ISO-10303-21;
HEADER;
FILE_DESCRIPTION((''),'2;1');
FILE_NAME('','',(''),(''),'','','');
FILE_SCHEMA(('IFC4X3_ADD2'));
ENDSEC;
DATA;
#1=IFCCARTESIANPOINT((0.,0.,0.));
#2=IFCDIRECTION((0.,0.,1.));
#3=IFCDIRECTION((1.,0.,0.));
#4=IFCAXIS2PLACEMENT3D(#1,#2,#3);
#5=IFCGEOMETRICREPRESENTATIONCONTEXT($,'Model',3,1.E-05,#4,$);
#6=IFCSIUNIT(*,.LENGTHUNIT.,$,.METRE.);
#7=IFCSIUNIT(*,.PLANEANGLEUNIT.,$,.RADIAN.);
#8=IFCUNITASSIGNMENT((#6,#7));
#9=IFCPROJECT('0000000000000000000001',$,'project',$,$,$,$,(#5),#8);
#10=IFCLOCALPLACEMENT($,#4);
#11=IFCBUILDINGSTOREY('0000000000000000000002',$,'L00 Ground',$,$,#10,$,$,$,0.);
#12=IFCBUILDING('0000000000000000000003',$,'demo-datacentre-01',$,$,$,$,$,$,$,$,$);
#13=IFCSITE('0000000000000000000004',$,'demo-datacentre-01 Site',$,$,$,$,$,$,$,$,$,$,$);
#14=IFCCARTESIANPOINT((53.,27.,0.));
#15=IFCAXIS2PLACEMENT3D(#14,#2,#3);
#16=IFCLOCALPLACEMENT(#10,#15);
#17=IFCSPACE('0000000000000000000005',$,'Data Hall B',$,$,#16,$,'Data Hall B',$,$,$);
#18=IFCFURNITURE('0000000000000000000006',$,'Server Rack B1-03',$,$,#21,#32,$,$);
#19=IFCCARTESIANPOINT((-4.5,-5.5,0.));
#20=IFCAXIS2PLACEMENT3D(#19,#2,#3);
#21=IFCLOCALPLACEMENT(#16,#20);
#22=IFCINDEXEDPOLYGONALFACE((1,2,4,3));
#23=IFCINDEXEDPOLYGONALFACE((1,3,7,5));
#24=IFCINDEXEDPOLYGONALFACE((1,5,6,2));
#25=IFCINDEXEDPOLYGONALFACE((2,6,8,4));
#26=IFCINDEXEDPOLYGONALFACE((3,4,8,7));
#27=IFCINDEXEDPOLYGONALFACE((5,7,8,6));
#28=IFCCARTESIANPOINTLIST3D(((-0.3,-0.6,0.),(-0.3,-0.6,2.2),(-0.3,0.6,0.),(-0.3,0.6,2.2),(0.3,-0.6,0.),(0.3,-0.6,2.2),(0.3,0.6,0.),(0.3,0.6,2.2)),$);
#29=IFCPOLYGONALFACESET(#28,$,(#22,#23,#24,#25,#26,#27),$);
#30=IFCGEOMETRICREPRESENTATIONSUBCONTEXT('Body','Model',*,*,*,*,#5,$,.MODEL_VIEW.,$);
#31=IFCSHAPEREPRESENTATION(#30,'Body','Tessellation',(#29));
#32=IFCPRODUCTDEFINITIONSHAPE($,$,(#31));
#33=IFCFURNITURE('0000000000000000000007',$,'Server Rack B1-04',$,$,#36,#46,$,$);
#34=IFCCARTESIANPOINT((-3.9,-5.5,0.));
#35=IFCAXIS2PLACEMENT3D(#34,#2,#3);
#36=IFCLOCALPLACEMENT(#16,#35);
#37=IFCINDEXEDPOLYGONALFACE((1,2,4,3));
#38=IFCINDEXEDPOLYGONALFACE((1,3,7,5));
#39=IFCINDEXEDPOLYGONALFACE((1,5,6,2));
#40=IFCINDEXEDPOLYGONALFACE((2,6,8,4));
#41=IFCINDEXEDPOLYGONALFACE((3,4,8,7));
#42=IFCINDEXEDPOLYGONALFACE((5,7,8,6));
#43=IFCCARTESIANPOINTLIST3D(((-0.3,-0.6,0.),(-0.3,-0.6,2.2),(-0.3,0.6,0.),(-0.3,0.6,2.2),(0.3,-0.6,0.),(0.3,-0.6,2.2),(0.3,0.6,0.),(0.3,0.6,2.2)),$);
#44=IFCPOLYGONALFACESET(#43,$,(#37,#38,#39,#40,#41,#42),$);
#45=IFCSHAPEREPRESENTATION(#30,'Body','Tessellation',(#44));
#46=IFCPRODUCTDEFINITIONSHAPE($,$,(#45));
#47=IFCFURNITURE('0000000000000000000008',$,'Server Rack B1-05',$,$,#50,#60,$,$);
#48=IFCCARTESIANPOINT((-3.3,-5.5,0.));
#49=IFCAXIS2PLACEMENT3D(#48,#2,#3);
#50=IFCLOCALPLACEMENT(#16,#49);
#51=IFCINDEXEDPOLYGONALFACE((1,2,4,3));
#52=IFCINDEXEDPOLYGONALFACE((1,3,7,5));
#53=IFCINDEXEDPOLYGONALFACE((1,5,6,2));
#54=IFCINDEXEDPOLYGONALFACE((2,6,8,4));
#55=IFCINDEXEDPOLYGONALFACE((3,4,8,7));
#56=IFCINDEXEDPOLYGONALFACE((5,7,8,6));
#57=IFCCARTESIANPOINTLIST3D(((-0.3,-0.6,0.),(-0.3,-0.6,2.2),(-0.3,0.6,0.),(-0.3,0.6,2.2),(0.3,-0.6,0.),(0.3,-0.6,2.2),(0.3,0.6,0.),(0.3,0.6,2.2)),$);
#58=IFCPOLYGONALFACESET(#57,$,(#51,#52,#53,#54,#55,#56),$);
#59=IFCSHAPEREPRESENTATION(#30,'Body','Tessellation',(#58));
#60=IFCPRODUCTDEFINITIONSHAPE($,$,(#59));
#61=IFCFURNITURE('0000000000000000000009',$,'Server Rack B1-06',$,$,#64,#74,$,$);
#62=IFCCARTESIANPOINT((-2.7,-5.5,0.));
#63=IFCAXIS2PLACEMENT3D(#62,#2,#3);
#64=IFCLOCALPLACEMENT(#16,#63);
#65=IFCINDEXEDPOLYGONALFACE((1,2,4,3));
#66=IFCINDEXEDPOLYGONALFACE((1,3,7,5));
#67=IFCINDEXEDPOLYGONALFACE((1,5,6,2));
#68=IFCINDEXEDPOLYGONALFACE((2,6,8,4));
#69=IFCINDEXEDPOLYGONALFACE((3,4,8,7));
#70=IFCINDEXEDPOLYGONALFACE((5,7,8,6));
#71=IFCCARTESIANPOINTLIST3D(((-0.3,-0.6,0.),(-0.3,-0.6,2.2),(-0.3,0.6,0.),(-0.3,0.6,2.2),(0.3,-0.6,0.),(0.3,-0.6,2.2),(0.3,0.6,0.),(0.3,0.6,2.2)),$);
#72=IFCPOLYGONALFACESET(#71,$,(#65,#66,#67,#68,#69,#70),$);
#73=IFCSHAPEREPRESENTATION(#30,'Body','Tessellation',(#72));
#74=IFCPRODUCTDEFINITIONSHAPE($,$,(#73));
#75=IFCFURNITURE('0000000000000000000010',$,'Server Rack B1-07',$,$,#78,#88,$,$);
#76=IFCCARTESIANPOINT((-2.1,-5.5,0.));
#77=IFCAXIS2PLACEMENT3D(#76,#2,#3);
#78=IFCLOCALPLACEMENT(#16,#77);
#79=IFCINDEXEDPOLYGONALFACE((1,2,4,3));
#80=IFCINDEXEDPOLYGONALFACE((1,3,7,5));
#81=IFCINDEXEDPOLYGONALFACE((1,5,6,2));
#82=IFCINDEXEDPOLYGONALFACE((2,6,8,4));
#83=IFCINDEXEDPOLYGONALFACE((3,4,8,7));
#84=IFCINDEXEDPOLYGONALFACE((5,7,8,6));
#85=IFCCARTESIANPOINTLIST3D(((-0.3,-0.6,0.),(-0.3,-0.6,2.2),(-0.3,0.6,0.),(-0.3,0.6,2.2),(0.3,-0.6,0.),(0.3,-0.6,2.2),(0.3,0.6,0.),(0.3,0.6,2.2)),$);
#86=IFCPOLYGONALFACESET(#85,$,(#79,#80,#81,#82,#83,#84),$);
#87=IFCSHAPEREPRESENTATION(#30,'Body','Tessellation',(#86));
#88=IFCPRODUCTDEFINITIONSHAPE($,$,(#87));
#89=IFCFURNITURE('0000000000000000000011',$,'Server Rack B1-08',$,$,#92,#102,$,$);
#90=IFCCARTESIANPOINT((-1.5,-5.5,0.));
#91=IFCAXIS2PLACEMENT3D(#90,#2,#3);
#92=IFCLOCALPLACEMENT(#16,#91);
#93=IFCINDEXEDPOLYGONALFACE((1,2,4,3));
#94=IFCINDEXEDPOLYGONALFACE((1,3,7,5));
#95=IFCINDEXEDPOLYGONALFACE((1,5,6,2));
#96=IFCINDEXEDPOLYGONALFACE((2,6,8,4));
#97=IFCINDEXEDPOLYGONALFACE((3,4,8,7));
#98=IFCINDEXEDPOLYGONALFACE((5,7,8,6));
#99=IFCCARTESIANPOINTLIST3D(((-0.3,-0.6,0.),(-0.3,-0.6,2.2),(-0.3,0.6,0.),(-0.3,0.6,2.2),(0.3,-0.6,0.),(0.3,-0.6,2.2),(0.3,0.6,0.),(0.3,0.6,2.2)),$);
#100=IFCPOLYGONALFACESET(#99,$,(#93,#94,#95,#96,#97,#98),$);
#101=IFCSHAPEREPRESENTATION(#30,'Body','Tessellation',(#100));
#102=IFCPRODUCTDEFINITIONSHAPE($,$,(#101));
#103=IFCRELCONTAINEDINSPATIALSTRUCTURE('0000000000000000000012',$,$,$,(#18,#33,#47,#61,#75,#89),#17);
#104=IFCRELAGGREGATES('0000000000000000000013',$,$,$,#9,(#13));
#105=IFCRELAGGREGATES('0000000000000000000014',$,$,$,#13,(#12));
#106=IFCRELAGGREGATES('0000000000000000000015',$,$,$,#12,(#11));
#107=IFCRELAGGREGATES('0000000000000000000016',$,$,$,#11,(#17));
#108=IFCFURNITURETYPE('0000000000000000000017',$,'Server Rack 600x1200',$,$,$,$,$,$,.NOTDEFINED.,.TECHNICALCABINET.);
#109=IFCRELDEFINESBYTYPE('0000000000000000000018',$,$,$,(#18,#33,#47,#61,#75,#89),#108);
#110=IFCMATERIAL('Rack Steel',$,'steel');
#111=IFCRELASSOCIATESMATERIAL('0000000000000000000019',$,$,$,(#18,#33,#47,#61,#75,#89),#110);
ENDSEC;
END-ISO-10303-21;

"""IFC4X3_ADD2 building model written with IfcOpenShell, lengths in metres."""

from ifc_helpers import new_model, si_unit, frame, origin_with_axes, place, context, subcontext, project, spatial, rectangle, extrude, material, type_object, element, save


model = new_model("IFC4X3_ADD2")

# Units and contexts
model_context = context("Model", 3, precision=1e-05, world=origin_with_axes())
body_context = subcontext(model_context, "Body", "Model", "MODEL_VIEW")
ifc_project = project(units=[si_unit("LENGTHUNIT", "METRE"), si_unit("PLANEANGLEUNIT", "RADIAN")], contexts=[model_context])

# Site, building, storey
site = spatial("IfcSite", under=ifc_project, Name="demo-datacentre-01 Site")
building = spatial("IfcBuilding", under=site, Name="demo-datacentre-01")
storey_placement = place(None, origin_with_axes())
storey = spatial("IfcBuildingStorey", under=building, at=storey_placement, Name="L00 Ground", Elevation=0.0)

# Shared definitions
space_placement = place(storey_placement, frame((53.0, 27.0, 0.0), z_axis=(0.0, 0.0, 1.0), x_axis=(1.0, 0.0, 0.0)))
space = spatial("IfcSpace", under=storey, at=space_placement, Name="Data Hall B", LongName="Data Hall B")

# Furniture
ifc_material_1 = material(Name="Rack Steel", Category="steel")
furniture_type = type_object("IfcFurnitureType", Name="Server Rack 600x1200", AssemblyPlace="NOTDEFINED", PredefinedType="TECHNICALCABINET")
for number, where, z_axis, x_axis, name in (
    (1, (-4.5, -5.5, 0.0), (0.0, 0.0, 1.0), (1.0, 0.0, 0.0), "Server Rack B1-03"),
    (2, (-3.9, -5.5, 0.0), (0.0, 0.0, 1.0), (1.0, 0.0, 0.0), "Server Rack B1-04"),
    (3, (-3.3, -5.5, 0.0), (0.0, 0.0, 1.0), (1.0, 0.0, 0.0), "Server Rack B1-05"),
    (4, (-2.7, -5.5, 0.0), (0.0, 0.0, 1.0), (1.0, 0.0, 0.0), "Server Rack B1-06"),
    (5, (-2.1, -5.5, 0.0), (0.0, 0.0, 1.0), (1.0, 0.0, 0.0), "Server Rack B1-07"),
    (6, (-1.5, -5.5, 0.0), (0.0, 0.0, 1.0), (1.0, 0.0, 0.0), "Server Rack B1-08"),
):
    element("IfcFurniture", number, at=place(space_placement, frame(where, z_axis=z_axis, x_axis=x_axis)), inside=space, type_object=furniture_type, material=ifc_material_1, Name=name, context=body_context, shape_type="SweptSolid", body=[
        extrude(rectangle(XDim=0.6, YDim=1.2), origin_with_axes(), (0.0, 0.0, 1.0), 2.2),
    ])

save(model, "model.ifc")
